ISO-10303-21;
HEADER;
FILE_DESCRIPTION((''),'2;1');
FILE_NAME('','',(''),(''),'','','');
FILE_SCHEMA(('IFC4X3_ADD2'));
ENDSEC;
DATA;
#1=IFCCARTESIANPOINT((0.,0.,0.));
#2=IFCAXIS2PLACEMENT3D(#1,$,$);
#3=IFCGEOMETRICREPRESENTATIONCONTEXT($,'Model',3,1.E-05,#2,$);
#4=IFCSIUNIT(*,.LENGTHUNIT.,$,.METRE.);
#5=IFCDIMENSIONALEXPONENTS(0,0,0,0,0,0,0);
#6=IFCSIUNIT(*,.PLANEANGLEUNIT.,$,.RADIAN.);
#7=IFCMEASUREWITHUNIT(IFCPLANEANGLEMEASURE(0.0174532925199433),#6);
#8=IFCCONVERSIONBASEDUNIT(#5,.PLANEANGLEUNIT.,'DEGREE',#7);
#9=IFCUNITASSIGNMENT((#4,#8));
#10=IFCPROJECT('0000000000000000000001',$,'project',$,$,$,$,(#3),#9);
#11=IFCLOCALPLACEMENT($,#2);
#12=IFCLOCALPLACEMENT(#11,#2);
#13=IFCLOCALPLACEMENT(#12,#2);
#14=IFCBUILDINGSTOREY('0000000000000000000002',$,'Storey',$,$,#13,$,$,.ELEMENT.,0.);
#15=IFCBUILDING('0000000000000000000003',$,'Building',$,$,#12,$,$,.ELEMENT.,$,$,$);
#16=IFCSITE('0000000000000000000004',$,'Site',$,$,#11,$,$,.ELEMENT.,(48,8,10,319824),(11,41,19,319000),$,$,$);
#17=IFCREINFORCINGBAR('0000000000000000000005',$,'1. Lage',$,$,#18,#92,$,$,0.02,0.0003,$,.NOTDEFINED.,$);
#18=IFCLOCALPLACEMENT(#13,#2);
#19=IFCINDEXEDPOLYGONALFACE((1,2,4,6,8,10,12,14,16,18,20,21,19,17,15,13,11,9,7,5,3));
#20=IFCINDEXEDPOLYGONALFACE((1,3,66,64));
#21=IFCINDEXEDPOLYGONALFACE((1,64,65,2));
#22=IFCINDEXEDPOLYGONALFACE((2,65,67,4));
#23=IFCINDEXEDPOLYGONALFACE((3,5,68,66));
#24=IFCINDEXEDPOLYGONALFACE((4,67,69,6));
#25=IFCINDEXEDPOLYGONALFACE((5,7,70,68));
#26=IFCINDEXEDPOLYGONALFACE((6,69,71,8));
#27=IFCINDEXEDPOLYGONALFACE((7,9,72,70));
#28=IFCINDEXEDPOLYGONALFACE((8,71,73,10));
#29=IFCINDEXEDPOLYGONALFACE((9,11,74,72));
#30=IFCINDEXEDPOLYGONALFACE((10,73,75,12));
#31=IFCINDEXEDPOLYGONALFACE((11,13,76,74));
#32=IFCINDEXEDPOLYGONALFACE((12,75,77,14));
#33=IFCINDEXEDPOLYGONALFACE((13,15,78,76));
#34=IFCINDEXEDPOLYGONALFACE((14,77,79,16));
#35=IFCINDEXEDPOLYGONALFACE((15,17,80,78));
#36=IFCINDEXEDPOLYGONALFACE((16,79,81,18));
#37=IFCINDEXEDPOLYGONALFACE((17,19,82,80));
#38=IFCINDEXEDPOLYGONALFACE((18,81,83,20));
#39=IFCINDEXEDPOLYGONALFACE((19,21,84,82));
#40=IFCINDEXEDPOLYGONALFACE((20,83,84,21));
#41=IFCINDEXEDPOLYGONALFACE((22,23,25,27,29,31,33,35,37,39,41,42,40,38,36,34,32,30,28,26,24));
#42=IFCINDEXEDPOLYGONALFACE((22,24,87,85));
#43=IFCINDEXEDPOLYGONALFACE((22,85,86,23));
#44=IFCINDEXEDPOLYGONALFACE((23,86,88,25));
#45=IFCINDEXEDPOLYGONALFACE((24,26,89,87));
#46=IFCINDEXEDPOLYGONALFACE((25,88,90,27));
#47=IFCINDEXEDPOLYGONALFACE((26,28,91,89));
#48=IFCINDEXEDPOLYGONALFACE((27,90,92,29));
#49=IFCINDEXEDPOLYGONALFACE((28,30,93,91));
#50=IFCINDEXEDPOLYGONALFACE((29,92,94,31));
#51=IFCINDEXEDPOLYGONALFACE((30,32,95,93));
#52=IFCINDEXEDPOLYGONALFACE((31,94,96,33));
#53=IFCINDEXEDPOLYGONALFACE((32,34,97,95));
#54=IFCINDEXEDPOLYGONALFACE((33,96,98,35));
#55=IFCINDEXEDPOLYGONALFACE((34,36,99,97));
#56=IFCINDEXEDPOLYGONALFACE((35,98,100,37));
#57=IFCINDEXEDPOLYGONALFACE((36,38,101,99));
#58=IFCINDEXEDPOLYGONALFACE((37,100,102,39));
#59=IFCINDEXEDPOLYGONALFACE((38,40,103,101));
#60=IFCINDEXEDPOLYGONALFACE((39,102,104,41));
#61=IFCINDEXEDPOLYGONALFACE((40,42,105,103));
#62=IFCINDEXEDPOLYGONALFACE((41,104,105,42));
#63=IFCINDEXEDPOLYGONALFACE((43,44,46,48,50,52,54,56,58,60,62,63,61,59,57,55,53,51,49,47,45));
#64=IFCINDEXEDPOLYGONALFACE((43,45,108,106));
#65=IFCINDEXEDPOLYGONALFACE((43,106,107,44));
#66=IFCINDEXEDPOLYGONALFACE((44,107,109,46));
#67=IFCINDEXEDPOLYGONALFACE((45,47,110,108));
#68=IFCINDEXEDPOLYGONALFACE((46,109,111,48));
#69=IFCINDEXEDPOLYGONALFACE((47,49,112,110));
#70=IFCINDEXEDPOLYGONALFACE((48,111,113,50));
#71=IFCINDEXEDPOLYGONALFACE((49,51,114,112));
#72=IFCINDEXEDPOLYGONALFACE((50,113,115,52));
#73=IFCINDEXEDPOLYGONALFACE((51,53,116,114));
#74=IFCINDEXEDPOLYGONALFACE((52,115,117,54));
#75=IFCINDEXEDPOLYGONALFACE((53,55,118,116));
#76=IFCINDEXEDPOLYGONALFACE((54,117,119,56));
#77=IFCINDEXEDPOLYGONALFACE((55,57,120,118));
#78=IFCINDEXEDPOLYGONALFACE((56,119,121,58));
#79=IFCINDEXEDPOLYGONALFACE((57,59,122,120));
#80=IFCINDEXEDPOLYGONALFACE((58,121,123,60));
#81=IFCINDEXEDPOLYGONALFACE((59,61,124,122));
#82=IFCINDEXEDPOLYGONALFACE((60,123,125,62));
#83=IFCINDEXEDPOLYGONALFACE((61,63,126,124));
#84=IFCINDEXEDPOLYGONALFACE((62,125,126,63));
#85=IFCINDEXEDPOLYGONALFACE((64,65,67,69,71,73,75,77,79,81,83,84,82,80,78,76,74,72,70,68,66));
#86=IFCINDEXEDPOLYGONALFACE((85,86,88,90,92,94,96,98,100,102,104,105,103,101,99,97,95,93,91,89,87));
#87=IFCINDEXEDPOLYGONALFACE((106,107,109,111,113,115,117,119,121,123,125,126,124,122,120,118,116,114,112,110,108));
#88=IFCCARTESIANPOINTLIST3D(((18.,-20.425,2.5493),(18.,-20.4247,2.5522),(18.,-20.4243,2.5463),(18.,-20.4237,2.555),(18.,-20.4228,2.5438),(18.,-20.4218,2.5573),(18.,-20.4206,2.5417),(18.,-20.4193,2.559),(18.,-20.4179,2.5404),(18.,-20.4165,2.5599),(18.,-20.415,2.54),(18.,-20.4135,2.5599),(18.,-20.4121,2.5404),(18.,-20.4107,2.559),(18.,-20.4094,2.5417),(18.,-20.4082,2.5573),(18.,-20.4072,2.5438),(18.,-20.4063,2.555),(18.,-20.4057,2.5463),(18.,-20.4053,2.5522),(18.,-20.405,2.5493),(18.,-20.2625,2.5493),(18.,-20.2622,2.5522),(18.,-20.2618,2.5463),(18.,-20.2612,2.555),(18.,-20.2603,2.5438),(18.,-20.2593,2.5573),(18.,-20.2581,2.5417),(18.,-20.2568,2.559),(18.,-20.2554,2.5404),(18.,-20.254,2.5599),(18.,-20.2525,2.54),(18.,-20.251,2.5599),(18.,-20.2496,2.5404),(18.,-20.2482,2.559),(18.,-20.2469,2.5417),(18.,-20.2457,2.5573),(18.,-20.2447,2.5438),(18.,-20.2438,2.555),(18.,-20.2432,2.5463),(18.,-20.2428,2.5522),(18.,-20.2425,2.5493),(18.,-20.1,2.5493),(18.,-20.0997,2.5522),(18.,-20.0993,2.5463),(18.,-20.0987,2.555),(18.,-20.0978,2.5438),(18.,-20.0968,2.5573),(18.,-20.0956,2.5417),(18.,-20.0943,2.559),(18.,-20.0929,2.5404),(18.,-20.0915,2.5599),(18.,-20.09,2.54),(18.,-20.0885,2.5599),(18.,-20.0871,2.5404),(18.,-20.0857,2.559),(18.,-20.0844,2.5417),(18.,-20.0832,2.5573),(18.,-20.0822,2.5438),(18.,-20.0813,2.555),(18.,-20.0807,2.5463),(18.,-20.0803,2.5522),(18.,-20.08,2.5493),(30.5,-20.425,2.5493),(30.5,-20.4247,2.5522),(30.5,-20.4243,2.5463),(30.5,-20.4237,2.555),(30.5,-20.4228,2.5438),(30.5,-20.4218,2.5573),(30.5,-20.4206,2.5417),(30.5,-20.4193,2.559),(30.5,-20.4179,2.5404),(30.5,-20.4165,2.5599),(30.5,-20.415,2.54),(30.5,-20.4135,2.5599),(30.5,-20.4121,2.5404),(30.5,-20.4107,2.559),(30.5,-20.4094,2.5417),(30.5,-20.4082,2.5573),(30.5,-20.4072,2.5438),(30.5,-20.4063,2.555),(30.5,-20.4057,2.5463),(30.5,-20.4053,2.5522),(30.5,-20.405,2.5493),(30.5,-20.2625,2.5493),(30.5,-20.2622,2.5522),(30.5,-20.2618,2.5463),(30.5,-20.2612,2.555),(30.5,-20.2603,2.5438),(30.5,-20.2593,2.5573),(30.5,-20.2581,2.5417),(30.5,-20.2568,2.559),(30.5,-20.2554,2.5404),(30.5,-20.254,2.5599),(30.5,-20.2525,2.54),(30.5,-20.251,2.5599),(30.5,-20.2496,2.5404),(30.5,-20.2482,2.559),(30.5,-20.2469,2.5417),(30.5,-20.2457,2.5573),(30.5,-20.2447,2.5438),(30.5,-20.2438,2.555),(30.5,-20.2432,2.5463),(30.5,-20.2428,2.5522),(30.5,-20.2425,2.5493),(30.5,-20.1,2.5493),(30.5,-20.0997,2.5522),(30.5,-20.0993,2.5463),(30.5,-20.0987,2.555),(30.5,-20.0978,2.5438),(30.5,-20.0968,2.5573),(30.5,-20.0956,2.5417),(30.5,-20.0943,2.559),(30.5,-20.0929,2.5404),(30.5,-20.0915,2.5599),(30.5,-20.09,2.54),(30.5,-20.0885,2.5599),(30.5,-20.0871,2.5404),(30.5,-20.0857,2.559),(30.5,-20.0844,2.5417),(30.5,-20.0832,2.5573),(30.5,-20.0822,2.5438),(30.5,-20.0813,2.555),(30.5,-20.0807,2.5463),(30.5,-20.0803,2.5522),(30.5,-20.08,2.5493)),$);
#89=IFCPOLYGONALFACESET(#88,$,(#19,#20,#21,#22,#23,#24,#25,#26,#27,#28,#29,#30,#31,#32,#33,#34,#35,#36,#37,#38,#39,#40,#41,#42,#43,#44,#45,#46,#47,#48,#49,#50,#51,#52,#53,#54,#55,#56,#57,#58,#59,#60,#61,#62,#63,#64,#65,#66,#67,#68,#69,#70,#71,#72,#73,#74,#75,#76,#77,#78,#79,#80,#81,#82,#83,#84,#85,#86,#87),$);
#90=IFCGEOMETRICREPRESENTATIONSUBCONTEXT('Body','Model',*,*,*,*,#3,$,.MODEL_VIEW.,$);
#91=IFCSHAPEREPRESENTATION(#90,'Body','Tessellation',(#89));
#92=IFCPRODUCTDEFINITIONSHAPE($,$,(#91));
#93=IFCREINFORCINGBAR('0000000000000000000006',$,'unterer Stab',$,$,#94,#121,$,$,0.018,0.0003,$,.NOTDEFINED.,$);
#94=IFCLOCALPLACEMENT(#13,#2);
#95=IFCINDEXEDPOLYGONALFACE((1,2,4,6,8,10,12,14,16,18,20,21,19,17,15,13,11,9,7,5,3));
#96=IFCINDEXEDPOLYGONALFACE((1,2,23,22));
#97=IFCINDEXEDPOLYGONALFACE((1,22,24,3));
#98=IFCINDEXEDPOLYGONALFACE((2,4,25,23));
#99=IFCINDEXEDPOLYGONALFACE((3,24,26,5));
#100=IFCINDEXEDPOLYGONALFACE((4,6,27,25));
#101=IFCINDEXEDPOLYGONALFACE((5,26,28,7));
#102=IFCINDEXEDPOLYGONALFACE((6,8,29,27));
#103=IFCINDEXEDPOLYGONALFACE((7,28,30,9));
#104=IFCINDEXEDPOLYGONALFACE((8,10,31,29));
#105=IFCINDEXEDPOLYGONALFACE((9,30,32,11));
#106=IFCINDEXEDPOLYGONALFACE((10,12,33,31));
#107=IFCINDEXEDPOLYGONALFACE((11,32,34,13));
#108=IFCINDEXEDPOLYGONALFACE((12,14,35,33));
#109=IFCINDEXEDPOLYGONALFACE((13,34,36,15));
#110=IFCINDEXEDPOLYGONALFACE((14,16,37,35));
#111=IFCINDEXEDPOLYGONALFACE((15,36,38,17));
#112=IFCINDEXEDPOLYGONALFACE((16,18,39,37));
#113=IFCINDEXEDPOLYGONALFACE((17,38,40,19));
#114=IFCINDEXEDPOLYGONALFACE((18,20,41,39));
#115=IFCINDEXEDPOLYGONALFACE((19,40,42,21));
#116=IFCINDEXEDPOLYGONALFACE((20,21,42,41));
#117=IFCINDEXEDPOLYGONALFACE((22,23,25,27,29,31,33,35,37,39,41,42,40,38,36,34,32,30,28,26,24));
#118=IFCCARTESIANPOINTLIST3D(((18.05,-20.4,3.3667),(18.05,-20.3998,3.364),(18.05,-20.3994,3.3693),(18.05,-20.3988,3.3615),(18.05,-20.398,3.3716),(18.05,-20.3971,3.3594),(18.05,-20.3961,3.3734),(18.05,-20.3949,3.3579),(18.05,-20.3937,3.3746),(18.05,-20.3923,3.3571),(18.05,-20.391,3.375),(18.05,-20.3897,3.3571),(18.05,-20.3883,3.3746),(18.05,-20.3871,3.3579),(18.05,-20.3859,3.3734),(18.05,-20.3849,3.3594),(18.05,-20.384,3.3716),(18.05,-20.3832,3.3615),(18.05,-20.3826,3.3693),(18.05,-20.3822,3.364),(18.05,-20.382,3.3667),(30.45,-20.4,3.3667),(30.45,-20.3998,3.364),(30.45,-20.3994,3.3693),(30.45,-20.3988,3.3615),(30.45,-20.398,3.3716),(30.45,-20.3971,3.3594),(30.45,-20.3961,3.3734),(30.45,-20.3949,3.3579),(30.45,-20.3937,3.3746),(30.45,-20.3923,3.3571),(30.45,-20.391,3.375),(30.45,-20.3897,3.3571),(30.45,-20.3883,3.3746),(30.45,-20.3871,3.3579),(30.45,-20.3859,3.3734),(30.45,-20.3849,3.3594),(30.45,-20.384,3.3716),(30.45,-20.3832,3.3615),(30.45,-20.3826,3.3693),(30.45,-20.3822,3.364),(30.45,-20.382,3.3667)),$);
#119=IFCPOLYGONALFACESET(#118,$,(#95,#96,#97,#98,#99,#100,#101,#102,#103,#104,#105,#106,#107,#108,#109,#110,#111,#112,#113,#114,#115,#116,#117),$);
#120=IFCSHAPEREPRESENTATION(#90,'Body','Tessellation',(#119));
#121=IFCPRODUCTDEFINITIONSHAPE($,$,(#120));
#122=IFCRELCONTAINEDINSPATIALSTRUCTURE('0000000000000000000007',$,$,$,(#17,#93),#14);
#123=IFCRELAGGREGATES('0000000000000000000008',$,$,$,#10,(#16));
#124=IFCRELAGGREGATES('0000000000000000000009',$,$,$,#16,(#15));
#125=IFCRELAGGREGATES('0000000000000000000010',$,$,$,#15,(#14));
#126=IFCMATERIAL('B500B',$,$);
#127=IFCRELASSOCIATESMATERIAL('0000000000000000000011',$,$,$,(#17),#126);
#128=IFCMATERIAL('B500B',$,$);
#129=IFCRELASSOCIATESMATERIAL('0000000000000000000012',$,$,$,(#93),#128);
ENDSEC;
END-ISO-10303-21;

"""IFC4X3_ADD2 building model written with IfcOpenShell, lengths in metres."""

from ifc_helpers import new_model, entity, si_unit, converted_unit, frame, origin, origin_with_axes, place, context, subcontext, project, spatial, source, transform, mapped, material, element, save


model = new_model("IFC4X3_ADD2")

# Units and contexts
model_context = context("Model", 3, precision=1e-05, world=origin())
body_context = subcontext(model_context, "Body", "Model", "MODEL_VIEW")
ifc_project = project(units=[si_unit("LENGTHUNIT", "METRE"), converted_unit("PLANEANGLEUNIT", "DEGREE", entity("IfcPlaneAngleMeasure", 0.0174532925199433), si_unit("PLANEANGLEUNIT", "RADIAN"), dimensions=[0, 0, 0, 0, 0, 0, 0])], contexts=[model_context])

# Site, building, storey
site_placement = place(None, origin())
site = spatial("IfcSite", under=ifc_project, at=site_placement, Name="Site", CompositionType="ELEMENT", RefLatitude=(48, 8, 10, 319824), RefLongitude=(11, 41, 19, 319000))
building_placement = place(site_placement, origin())
building = spatial("IfcBuilding", under=site, at=building_placement, Name="Building", CompositionType="ELEMENT")
storey_placement = place(building_placement, origin())
storey = spatial("IfcBuildingStorey", under=building, at=storey_placement, Name="Storey", CompositionType="ELEMENT", Elevation=0.0)

# Reinforcing bars
ifc_material_1 = material(Name="B500B")
shared_shape_1 = source(origin_with_axes(), body_context, "Body", "AdvancedSweptSolid", [
    entity("IfcSweptDiskSolid", entity("IfcIndexedPolyCurve", entity("IfcCartesianPointList3D", [[0.0, 0.0, 0.0], [-12.5, 0.0, 0.0]]), [entity("IfcLineIndex", [1, 2])]), 0.01, None, 0.0, 1.0),
])
reinforcing_bar_1_placement = place(storey_placement, frame((30.5, -20.415, 2.55)))
element("IfcReinforcingBar", 1, at=reinforcing_bar_1_placement, inside=storey, material=ifc_material_1, Name="1. Lage", CrossSectionArea=0.0003, NominalDiameter=0.02, PredefinedType="NOTDEFINED", context=body_context, shape_type="MappedRepresentation", body=[
    mapped(shared_shape_1, transform((0.0, 0.0, 0.0), x_axis=(1.0, 0.0, 0.0), y_axis=(0.0, 1.0, 0.0), z_axis=(0.0, 0.0, 1.0), scale=1.0)),
    mapped(shared_shape_1, transform((0.0, 0.1625, 0.0), x_axis=(1.0, 0.0, 0.0), y_axis=(0.0, 1.0, 0.0), z_axis=(0.0, 0.0, 1.0), scale=1.0)),
    mapped(shared_shape_1, transform((0.0, 0.325, 0.0), x_axis=(1.0, 0.0, 0.0), y_axis=(0.0, 1.0, 0.0), z_axis=(0.0, 0.0, 1.0), scale=1.0)),
])
ifc_material_2 = material(Name="B500B")
shared_shape_2 = source(origin_with_axes(), body_context, "Body", "AdvancedSweptSolid", [
    entity("IfcSweptDiskSolid", entity("IfcIndexedPolyCurve", entity("IfcCartesianPointList3D", [[0.0, 0.0, 0.0], [12.4, 0.0, 0.0]]), [entity("IfcLineIndex", [1, 2])]), 0.009, None, 0.0, 1.0),
])
reinforcing_bar_2_placement = place(storey_placement, frame((18.05, -20.391, 3.366)))
element("IfcReinforcingBar", 2, at=reinforcing_bar_2_placement, inside=storey, material=ifc_material_2, Name="unterer Stab", CrossSectionArea=0.0003, NominalDiameter=0.018, PredefinedType="NOTDEFINED", context=body_context, shape_type="MappedRepresentation", body=[
    mapped(shared_shape_2, transform((0.0, 0.0, 0.0), x_axis=(1.0, 0.0, 0.0), y_axis=(0.0, 1.0, 0.0), z_axis=(0.0, 0.0, 1.0), scale=1.0)),
])

save(model, "model.ifc")
